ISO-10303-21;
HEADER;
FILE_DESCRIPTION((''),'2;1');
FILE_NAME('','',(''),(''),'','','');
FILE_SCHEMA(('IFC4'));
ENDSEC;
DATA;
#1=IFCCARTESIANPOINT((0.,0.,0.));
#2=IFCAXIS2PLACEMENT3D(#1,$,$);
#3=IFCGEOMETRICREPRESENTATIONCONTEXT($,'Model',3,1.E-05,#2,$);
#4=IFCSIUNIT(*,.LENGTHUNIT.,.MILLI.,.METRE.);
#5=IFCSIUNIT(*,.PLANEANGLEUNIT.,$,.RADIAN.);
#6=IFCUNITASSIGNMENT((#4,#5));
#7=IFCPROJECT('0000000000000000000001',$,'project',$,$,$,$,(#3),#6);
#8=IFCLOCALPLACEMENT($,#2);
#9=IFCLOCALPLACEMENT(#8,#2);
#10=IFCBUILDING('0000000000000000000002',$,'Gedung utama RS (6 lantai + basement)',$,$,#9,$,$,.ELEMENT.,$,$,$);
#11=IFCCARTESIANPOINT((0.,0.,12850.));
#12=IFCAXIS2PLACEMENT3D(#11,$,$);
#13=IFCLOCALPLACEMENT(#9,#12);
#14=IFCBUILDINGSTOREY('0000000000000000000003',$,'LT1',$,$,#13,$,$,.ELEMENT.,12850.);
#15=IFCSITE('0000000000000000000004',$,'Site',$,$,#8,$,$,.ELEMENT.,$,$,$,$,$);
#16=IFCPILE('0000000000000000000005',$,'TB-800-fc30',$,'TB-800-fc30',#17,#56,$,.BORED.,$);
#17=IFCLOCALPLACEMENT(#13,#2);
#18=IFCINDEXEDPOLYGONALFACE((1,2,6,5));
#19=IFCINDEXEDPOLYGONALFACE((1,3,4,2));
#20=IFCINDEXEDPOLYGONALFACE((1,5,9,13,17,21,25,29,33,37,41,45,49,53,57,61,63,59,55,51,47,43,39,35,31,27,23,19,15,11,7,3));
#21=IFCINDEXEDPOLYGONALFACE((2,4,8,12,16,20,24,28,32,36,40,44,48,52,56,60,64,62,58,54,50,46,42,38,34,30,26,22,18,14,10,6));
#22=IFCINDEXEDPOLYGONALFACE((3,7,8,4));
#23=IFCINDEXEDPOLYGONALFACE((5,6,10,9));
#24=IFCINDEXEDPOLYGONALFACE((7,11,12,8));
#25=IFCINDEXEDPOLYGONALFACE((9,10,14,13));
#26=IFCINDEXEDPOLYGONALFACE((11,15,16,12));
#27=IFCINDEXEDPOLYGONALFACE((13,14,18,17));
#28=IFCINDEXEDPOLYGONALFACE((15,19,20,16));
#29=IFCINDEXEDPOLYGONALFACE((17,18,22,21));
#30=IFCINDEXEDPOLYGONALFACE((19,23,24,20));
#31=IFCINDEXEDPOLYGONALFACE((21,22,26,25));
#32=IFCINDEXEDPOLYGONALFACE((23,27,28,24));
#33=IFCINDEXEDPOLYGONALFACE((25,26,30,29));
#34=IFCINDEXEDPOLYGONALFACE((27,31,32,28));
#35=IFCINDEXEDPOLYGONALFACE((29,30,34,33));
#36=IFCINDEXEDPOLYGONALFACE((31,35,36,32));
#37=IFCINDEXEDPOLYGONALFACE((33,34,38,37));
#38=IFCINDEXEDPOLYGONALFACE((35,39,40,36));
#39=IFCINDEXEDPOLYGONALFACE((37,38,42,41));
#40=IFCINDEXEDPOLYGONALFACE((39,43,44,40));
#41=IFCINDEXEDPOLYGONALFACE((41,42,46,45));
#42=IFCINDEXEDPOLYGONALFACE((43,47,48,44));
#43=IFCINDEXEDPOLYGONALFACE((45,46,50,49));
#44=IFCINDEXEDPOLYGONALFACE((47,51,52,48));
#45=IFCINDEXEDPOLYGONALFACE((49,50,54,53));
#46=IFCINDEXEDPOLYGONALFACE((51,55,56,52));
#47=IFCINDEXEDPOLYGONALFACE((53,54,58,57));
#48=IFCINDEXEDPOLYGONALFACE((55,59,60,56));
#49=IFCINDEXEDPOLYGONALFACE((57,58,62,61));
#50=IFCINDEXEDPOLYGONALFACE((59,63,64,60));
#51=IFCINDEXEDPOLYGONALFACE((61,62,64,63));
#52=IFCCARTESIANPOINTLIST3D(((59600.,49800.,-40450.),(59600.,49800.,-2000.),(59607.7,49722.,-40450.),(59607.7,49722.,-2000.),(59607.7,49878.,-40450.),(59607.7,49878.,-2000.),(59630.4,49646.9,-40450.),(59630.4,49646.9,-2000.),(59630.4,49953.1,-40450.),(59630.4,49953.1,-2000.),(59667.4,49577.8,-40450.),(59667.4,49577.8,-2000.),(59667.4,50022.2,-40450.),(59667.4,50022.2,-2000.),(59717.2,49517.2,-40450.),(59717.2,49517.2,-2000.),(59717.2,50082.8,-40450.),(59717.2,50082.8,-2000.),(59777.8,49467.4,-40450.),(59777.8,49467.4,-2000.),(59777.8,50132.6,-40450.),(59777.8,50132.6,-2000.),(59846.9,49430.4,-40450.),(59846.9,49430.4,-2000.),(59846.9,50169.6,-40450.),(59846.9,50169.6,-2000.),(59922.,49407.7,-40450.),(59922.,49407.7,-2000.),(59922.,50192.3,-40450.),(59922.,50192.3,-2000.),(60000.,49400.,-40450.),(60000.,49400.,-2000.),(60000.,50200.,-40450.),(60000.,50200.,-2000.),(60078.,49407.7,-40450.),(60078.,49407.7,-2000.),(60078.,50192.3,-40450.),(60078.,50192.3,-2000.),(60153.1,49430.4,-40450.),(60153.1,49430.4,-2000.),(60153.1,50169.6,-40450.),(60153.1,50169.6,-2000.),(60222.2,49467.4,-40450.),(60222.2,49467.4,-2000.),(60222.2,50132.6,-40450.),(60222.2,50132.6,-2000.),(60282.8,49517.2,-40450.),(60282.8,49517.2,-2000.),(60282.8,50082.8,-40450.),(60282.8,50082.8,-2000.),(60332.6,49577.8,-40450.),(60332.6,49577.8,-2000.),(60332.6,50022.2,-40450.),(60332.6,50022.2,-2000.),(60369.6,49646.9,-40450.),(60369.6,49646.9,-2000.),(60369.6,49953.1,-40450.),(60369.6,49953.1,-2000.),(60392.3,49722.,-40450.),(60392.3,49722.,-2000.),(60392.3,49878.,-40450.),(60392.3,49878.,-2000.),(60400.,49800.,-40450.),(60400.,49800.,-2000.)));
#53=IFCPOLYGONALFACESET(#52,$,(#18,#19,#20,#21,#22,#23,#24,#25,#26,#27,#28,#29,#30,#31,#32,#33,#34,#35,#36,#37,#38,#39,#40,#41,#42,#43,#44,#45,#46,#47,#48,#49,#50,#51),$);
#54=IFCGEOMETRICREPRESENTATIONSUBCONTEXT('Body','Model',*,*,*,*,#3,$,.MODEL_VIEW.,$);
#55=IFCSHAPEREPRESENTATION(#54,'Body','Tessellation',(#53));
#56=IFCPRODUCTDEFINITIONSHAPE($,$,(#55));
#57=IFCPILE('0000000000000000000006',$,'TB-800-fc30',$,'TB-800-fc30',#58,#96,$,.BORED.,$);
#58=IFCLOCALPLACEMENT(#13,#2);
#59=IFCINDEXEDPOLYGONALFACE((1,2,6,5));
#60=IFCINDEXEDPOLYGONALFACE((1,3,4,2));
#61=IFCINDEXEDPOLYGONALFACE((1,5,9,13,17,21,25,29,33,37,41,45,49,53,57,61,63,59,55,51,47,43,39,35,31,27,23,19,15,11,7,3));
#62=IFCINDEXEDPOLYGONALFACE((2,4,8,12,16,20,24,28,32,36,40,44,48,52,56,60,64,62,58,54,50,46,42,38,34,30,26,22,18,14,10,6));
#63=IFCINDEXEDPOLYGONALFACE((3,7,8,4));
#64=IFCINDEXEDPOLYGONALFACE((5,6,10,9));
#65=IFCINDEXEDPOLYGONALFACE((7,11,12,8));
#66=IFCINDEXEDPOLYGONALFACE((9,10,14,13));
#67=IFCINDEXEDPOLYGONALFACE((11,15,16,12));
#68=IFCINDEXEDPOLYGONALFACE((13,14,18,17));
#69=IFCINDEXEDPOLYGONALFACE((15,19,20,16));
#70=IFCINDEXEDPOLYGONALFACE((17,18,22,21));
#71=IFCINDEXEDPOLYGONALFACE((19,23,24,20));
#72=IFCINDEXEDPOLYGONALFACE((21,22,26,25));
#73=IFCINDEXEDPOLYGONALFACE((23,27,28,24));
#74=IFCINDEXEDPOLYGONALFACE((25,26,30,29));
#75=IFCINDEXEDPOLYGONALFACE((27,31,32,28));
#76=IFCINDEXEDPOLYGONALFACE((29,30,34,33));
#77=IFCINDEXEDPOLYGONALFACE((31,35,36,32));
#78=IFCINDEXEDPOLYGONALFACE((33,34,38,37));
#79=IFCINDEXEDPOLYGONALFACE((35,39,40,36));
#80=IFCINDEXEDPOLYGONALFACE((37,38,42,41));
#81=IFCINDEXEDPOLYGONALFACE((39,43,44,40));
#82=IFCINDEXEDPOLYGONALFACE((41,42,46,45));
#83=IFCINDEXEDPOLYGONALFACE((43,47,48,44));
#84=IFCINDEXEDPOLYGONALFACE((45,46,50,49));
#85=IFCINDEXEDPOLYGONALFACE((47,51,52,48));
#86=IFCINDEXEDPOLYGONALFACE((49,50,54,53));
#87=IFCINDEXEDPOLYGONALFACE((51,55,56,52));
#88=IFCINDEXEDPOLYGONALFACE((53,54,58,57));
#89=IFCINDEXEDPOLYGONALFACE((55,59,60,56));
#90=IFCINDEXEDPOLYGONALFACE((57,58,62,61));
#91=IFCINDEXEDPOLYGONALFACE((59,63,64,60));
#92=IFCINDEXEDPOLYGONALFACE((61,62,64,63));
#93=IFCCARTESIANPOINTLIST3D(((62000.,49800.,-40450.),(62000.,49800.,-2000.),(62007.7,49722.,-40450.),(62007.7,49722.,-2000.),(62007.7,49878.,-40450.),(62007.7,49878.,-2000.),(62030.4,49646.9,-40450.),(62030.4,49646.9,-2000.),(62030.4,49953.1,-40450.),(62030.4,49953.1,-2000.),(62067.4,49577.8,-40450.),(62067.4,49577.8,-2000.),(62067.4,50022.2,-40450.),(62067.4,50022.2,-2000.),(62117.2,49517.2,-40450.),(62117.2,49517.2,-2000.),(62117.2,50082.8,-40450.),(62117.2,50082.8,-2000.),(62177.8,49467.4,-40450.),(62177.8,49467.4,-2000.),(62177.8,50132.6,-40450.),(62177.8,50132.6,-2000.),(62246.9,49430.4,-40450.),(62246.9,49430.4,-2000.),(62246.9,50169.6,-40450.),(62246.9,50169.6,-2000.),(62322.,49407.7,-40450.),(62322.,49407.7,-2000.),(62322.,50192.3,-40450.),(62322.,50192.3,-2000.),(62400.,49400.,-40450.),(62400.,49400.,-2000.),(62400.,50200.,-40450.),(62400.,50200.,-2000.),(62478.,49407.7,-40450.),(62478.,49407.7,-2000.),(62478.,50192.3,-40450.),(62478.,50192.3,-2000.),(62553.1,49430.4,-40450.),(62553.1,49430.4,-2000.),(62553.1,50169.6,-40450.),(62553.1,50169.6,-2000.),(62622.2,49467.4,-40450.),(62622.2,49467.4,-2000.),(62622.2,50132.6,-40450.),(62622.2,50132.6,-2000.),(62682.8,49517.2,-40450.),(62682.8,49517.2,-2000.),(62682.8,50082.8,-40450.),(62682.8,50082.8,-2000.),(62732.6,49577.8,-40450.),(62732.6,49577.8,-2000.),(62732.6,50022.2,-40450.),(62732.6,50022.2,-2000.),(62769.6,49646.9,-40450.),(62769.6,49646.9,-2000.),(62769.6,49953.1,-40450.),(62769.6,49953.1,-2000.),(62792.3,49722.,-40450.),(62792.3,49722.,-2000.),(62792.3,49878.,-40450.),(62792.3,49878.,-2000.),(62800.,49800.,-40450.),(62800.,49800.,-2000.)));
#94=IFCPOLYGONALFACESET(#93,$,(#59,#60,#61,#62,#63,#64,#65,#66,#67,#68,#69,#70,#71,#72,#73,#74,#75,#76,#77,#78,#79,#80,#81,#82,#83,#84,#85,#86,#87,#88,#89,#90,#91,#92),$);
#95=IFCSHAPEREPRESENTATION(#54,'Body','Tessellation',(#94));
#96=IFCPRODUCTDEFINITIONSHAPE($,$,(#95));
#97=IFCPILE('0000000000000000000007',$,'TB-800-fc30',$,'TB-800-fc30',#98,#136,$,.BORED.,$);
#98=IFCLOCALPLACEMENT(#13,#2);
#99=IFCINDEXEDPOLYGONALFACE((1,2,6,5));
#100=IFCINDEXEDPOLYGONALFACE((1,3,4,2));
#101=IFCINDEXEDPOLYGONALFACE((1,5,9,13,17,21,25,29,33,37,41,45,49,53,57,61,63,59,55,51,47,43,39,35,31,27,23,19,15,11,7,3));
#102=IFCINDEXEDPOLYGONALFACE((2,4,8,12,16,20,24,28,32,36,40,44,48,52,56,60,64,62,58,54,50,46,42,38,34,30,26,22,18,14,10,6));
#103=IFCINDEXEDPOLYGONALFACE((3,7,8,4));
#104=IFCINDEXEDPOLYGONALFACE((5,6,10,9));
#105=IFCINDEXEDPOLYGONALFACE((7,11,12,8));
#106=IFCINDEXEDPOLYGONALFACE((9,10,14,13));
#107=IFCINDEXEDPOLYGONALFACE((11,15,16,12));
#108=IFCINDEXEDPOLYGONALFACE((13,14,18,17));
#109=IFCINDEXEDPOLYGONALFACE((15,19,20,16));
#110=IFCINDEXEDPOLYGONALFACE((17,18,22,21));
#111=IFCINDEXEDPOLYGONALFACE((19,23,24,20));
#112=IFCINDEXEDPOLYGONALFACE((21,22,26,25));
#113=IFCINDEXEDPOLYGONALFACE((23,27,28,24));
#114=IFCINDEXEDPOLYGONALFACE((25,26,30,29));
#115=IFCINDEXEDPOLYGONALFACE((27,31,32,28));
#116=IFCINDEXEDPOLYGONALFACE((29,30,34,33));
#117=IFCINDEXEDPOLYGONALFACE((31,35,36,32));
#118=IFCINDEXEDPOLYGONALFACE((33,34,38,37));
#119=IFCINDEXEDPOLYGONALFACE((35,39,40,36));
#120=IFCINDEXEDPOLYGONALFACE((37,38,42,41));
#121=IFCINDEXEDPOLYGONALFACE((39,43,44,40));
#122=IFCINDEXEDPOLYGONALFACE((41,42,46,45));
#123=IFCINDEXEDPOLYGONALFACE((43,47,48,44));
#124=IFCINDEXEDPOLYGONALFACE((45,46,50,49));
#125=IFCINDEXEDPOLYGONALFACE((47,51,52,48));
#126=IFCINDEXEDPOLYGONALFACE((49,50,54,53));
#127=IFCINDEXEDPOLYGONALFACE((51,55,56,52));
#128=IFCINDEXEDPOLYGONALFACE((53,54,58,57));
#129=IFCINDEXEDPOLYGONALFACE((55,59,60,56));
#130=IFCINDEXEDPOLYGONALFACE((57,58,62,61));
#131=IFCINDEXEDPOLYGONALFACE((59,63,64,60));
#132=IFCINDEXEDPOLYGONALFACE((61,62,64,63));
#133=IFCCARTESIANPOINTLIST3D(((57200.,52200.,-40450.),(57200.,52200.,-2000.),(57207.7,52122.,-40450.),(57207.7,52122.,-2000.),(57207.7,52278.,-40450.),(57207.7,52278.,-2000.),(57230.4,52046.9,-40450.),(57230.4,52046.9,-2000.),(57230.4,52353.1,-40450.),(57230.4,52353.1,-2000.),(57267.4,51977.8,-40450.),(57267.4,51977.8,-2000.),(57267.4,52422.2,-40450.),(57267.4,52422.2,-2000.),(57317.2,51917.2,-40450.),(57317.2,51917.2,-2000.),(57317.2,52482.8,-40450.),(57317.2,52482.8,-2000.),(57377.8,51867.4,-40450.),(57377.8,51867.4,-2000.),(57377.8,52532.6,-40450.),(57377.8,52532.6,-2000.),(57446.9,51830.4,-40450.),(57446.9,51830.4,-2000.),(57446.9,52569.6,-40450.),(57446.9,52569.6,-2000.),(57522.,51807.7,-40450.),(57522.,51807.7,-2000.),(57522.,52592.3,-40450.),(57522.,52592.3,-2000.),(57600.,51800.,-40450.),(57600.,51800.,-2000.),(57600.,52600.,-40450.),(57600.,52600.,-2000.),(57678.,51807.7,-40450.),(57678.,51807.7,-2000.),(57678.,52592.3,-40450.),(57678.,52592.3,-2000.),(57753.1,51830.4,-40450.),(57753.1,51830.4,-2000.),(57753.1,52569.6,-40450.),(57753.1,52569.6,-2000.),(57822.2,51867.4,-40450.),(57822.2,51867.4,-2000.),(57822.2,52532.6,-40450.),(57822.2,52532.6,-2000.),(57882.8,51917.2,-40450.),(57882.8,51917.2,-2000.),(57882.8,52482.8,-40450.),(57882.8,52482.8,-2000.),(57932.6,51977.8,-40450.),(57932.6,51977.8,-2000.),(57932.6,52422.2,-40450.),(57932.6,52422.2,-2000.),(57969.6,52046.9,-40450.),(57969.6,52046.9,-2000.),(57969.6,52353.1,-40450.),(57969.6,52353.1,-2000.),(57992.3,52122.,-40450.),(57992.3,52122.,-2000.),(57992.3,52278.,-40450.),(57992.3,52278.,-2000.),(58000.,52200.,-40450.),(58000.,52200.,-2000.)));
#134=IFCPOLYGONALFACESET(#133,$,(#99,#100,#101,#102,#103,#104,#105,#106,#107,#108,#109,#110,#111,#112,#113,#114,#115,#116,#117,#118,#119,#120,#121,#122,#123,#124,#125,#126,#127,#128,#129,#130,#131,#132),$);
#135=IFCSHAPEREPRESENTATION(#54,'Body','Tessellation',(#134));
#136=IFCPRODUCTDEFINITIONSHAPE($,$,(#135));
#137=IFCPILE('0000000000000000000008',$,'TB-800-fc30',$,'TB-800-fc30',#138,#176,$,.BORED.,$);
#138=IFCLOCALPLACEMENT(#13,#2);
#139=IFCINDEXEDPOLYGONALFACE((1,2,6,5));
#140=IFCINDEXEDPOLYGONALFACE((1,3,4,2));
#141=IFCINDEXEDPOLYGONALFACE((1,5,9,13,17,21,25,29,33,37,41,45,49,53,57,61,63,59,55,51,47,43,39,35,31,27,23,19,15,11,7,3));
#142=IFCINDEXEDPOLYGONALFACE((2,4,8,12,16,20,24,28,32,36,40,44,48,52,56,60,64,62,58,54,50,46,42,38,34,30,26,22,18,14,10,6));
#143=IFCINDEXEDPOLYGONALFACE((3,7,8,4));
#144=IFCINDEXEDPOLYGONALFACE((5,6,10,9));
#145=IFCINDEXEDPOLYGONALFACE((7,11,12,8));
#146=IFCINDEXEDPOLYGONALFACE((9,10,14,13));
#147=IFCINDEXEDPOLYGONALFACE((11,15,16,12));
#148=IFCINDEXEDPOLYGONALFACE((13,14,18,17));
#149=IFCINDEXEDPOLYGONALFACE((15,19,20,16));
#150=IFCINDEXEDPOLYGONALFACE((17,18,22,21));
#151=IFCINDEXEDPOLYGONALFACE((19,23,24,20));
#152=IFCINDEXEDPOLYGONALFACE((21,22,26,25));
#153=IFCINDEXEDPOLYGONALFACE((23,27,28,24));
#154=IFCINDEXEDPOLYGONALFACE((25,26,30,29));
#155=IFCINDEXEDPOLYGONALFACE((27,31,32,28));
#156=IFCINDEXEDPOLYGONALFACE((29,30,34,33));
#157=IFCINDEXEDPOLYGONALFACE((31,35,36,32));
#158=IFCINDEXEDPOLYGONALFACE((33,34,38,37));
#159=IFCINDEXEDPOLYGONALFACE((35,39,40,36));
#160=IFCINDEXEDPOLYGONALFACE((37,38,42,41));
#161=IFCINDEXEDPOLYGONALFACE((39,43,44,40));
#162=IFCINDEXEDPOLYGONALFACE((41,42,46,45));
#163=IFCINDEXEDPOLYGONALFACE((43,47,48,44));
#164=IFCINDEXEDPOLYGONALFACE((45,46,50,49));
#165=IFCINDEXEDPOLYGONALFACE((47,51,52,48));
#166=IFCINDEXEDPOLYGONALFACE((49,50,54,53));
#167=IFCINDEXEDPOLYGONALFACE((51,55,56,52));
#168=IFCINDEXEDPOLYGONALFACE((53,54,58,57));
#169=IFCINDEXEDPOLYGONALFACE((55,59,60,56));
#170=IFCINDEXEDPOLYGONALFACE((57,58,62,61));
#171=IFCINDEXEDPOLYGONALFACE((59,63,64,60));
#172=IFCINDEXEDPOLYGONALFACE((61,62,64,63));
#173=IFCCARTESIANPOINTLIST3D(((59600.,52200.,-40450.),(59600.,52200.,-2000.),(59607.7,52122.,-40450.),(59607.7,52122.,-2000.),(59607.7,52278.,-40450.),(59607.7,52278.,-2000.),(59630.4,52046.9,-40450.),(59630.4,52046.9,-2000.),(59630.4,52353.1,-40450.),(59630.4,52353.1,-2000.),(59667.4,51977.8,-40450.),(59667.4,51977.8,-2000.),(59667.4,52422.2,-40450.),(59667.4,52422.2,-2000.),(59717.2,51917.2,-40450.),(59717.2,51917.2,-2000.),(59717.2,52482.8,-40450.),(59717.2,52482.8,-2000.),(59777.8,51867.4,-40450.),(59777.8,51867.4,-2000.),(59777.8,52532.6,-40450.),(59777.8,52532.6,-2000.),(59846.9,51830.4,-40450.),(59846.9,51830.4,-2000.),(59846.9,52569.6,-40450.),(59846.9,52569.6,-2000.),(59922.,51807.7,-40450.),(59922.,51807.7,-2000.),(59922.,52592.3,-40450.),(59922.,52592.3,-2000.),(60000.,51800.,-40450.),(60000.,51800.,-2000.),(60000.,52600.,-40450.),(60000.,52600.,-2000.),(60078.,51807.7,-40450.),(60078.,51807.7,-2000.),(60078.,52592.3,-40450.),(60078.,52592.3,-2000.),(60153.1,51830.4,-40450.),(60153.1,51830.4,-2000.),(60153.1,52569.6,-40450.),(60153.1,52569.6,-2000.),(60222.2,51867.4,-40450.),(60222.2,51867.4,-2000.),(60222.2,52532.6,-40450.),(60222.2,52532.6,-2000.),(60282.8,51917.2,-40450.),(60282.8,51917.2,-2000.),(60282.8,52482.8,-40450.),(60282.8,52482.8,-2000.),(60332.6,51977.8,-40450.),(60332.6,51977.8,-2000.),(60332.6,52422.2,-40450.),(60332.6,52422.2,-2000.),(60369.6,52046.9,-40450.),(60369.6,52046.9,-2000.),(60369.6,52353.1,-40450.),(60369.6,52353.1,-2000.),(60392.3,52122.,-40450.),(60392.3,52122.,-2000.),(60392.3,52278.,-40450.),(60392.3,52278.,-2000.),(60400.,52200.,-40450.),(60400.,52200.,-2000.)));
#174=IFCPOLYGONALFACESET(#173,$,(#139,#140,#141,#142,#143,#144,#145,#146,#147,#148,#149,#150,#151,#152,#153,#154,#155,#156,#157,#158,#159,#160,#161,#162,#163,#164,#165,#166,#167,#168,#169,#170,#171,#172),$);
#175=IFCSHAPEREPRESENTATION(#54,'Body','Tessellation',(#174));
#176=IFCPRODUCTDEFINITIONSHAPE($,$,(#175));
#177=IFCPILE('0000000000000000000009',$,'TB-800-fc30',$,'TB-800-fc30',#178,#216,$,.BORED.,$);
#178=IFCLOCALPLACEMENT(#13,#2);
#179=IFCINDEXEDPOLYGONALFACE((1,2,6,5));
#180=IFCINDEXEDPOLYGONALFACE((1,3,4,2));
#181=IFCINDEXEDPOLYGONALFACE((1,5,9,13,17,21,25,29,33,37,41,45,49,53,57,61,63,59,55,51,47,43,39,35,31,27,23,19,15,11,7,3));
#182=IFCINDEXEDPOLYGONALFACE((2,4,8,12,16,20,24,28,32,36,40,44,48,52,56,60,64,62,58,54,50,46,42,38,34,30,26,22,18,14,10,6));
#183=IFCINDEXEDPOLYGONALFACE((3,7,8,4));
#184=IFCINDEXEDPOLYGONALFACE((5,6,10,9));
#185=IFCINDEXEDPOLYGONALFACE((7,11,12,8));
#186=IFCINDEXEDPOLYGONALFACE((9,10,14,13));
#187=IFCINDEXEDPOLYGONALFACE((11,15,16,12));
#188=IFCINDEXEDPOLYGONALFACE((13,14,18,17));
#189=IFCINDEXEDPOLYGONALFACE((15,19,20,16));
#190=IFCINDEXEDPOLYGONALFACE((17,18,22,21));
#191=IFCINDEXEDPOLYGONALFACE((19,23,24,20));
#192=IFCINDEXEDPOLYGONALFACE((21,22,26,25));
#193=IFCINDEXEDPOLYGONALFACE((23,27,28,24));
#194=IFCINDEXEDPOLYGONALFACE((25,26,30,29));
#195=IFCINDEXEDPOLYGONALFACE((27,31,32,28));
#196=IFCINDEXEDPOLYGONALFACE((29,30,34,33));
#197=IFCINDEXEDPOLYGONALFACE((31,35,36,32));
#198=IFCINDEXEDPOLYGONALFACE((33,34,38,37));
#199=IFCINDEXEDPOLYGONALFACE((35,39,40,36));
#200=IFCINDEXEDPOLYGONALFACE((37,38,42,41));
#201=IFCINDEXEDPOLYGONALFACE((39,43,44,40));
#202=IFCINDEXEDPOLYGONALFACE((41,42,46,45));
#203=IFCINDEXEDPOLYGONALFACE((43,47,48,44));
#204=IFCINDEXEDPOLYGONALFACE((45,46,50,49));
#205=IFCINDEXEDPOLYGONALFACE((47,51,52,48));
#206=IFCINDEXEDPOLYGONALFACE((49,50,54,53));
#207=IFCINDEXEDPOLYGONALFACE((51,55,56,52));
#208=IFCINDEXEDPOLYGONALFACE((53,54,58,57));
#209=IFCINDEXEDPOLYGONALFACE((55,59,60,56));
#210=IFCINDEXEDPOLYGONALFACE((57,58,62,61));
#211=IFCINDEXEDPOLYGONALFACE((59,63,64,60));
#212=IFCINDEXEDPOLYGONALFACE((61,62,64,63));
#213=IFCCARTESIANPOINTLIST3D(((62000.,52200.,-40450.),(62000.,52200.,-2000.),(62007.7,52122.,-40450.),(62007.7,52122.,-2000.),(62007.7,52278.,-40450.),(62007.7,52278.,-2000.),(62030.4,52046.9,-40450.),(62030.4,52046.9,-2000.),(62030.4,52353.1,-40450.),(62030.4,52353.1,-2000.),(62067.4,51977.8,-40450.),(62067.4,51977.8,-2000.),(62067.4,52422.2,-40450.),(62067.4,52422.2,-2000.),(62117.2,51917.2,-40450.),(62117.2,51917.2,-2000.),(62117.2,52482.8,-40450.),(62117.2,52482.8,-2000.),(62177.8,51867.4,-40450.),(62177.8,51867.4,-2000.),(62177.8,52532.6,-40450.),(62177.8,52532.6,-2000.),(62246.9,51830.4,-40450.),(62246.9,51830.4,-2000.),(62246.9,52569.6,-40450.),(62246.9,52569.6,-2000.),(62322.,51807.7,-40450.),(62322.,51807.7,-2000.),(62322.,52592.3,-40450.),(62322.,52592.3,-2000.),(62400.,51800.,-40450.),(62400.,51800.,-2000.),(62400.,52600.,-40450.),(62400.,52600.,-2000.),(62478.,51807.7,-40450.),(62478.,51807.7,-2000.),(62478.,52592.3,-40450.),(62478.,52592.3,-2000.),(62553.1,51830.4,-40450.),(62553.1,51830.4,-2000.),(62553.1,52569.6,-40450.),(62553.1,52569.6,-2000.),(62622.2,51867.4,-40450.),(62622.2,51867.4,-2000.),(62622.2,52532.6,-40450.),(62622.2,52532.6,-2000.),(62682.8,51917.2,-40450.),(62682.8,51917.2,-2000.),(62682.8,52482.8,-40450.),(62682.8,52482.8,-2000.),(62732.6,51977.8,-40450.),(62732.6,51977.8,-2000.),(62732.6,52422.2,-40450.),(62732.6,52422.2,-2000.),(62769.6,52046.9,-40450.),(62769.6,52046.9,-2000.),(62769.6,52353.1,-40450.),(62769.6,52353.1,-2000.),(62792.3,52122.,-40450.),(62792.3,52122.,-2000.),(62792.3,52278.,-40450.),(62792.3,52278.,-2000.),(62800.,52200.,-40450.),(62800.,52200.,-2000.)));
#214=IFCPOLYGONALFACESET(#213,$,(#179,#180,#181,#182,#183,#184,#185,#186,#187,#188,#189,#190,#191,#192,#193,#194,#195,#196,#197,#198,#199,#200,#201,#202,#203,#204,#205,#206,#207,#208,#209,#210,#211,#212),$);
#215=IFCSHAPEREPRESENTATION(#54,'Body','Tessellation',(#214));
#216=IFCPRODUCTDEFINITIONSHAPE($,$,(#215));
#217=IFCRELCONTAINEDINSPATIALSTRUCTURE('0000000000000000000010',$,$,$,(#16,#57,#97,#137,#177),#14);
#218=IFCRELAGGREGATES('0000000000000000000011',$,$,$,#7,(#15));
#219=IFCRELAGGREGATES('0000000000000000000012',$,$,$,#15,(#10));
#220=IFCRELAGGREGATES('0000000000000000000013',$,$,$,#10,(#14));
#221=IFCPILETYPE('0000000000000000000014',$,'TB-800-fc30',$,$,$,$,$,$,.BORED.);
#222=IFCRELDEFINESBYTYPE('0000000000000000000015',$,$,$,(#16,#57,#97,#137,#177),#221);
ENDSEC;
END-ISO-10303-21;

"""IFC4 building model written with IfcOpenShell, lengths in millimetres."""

from ifc_helpers import new_model, si_unit, frame, origin, origin_2d, place, context, subcontext, project, spatial, circle, extrude, material_profile, profile_set, profile_usage, type_object, element, save


model = new_model("IFC4")

# Units and contexts
model_context = context("Model", 3, precision=1e-05, world=origin())
body_context = subcontext(model_context, "Body", "Model", "MODEL_VIEW")
ifc_project = project(units=[si_unit("LENGTHUNIT", "METRE", prefix="MILLI"), si_unit("PLANEANGLEUNIT", "RADIAN")], contexts=[model_context])

# Site, building, storey
site_placement = place(None, origin())
site = spatial("IfcSite", under=ifc_project, at=site_placement, Name="Site", CompositionType="ELEMENT")
building_placement = place(site_placement, origin())
building = spatial("IfcBuilding", under=site, at=building_placement, Name="Gedung utama RS (6 lantai + basement)", CompositionType="ELEMENT")
storey_placement = place(building_placement, frame((0.0, 0.0, 12850.0)))
storey = spatial("IfcBuildingStorey", under=building, at=storey_placement, Name="LT1", CompositionType="ELEMENT", Elevation=12850.0)

# Piles
ifc_material_profile = material_profile(None, circle(Radius=400.0, at=origin_2d()), Name="TB-800-fc30")
ifc_profile_set = profile_set([ifc_material_profile], Name="TB-800-fc30")
ifc_profile_usage = profile_usage(ifc_profile_set, cardinal=5)
pile_type = type_object("IfcPileType", Name="TB-800-fc30", PredefinedType="BORED", material=ifc_profile_set)
for number, where, z_axis, x_axis, name in (
    (1, (60000.0, 49800.0, -40450.0), (0.0, 0.0, 1.0), (1.0, 0.0, 0.0), "TB-800-fc30"),
    (2, (62400.0, 49800.0, -40450.0), (0.0, 0.0, 1.0), (1.0, 0.0, 0.0), "TB-800-fc30"),
    (3, (57600.0, 52200.0, -40450.0), (0.0, 0.0, 1.0), (1.0, 0.0, 0.0), "TB-800-fc30"),
    (4, (60000.0, 52200.0, -40450.0), (0.0, 0.0, 1.0), (1.0, 0.0, 0.0), "TB-800-fc30"),
    (5, (62400.0, 52200.0, -40450.0), (0.0, 0.0, 1.0), (1.0, 0.0, 0.0), "TB-800-fc30"),
):
    element("IfcPile", number, at=place(storey_placement, frame(where, z_axis=z_axis, x_axis=x_axis)), inside=storey, type_object=pile_type, material=ifc_profile_usage, Name=name, ObjectType="TB-800-fc30", PredefinedType="BORED", context=body_context, shape_type="SweptSolid", body=[
        extrude(circle(Radius=400.0, at=origin_2d()), origin(), (0.0, 0.0, 1.0), 38450.0),
    ])

save(model, "model.ifc")
